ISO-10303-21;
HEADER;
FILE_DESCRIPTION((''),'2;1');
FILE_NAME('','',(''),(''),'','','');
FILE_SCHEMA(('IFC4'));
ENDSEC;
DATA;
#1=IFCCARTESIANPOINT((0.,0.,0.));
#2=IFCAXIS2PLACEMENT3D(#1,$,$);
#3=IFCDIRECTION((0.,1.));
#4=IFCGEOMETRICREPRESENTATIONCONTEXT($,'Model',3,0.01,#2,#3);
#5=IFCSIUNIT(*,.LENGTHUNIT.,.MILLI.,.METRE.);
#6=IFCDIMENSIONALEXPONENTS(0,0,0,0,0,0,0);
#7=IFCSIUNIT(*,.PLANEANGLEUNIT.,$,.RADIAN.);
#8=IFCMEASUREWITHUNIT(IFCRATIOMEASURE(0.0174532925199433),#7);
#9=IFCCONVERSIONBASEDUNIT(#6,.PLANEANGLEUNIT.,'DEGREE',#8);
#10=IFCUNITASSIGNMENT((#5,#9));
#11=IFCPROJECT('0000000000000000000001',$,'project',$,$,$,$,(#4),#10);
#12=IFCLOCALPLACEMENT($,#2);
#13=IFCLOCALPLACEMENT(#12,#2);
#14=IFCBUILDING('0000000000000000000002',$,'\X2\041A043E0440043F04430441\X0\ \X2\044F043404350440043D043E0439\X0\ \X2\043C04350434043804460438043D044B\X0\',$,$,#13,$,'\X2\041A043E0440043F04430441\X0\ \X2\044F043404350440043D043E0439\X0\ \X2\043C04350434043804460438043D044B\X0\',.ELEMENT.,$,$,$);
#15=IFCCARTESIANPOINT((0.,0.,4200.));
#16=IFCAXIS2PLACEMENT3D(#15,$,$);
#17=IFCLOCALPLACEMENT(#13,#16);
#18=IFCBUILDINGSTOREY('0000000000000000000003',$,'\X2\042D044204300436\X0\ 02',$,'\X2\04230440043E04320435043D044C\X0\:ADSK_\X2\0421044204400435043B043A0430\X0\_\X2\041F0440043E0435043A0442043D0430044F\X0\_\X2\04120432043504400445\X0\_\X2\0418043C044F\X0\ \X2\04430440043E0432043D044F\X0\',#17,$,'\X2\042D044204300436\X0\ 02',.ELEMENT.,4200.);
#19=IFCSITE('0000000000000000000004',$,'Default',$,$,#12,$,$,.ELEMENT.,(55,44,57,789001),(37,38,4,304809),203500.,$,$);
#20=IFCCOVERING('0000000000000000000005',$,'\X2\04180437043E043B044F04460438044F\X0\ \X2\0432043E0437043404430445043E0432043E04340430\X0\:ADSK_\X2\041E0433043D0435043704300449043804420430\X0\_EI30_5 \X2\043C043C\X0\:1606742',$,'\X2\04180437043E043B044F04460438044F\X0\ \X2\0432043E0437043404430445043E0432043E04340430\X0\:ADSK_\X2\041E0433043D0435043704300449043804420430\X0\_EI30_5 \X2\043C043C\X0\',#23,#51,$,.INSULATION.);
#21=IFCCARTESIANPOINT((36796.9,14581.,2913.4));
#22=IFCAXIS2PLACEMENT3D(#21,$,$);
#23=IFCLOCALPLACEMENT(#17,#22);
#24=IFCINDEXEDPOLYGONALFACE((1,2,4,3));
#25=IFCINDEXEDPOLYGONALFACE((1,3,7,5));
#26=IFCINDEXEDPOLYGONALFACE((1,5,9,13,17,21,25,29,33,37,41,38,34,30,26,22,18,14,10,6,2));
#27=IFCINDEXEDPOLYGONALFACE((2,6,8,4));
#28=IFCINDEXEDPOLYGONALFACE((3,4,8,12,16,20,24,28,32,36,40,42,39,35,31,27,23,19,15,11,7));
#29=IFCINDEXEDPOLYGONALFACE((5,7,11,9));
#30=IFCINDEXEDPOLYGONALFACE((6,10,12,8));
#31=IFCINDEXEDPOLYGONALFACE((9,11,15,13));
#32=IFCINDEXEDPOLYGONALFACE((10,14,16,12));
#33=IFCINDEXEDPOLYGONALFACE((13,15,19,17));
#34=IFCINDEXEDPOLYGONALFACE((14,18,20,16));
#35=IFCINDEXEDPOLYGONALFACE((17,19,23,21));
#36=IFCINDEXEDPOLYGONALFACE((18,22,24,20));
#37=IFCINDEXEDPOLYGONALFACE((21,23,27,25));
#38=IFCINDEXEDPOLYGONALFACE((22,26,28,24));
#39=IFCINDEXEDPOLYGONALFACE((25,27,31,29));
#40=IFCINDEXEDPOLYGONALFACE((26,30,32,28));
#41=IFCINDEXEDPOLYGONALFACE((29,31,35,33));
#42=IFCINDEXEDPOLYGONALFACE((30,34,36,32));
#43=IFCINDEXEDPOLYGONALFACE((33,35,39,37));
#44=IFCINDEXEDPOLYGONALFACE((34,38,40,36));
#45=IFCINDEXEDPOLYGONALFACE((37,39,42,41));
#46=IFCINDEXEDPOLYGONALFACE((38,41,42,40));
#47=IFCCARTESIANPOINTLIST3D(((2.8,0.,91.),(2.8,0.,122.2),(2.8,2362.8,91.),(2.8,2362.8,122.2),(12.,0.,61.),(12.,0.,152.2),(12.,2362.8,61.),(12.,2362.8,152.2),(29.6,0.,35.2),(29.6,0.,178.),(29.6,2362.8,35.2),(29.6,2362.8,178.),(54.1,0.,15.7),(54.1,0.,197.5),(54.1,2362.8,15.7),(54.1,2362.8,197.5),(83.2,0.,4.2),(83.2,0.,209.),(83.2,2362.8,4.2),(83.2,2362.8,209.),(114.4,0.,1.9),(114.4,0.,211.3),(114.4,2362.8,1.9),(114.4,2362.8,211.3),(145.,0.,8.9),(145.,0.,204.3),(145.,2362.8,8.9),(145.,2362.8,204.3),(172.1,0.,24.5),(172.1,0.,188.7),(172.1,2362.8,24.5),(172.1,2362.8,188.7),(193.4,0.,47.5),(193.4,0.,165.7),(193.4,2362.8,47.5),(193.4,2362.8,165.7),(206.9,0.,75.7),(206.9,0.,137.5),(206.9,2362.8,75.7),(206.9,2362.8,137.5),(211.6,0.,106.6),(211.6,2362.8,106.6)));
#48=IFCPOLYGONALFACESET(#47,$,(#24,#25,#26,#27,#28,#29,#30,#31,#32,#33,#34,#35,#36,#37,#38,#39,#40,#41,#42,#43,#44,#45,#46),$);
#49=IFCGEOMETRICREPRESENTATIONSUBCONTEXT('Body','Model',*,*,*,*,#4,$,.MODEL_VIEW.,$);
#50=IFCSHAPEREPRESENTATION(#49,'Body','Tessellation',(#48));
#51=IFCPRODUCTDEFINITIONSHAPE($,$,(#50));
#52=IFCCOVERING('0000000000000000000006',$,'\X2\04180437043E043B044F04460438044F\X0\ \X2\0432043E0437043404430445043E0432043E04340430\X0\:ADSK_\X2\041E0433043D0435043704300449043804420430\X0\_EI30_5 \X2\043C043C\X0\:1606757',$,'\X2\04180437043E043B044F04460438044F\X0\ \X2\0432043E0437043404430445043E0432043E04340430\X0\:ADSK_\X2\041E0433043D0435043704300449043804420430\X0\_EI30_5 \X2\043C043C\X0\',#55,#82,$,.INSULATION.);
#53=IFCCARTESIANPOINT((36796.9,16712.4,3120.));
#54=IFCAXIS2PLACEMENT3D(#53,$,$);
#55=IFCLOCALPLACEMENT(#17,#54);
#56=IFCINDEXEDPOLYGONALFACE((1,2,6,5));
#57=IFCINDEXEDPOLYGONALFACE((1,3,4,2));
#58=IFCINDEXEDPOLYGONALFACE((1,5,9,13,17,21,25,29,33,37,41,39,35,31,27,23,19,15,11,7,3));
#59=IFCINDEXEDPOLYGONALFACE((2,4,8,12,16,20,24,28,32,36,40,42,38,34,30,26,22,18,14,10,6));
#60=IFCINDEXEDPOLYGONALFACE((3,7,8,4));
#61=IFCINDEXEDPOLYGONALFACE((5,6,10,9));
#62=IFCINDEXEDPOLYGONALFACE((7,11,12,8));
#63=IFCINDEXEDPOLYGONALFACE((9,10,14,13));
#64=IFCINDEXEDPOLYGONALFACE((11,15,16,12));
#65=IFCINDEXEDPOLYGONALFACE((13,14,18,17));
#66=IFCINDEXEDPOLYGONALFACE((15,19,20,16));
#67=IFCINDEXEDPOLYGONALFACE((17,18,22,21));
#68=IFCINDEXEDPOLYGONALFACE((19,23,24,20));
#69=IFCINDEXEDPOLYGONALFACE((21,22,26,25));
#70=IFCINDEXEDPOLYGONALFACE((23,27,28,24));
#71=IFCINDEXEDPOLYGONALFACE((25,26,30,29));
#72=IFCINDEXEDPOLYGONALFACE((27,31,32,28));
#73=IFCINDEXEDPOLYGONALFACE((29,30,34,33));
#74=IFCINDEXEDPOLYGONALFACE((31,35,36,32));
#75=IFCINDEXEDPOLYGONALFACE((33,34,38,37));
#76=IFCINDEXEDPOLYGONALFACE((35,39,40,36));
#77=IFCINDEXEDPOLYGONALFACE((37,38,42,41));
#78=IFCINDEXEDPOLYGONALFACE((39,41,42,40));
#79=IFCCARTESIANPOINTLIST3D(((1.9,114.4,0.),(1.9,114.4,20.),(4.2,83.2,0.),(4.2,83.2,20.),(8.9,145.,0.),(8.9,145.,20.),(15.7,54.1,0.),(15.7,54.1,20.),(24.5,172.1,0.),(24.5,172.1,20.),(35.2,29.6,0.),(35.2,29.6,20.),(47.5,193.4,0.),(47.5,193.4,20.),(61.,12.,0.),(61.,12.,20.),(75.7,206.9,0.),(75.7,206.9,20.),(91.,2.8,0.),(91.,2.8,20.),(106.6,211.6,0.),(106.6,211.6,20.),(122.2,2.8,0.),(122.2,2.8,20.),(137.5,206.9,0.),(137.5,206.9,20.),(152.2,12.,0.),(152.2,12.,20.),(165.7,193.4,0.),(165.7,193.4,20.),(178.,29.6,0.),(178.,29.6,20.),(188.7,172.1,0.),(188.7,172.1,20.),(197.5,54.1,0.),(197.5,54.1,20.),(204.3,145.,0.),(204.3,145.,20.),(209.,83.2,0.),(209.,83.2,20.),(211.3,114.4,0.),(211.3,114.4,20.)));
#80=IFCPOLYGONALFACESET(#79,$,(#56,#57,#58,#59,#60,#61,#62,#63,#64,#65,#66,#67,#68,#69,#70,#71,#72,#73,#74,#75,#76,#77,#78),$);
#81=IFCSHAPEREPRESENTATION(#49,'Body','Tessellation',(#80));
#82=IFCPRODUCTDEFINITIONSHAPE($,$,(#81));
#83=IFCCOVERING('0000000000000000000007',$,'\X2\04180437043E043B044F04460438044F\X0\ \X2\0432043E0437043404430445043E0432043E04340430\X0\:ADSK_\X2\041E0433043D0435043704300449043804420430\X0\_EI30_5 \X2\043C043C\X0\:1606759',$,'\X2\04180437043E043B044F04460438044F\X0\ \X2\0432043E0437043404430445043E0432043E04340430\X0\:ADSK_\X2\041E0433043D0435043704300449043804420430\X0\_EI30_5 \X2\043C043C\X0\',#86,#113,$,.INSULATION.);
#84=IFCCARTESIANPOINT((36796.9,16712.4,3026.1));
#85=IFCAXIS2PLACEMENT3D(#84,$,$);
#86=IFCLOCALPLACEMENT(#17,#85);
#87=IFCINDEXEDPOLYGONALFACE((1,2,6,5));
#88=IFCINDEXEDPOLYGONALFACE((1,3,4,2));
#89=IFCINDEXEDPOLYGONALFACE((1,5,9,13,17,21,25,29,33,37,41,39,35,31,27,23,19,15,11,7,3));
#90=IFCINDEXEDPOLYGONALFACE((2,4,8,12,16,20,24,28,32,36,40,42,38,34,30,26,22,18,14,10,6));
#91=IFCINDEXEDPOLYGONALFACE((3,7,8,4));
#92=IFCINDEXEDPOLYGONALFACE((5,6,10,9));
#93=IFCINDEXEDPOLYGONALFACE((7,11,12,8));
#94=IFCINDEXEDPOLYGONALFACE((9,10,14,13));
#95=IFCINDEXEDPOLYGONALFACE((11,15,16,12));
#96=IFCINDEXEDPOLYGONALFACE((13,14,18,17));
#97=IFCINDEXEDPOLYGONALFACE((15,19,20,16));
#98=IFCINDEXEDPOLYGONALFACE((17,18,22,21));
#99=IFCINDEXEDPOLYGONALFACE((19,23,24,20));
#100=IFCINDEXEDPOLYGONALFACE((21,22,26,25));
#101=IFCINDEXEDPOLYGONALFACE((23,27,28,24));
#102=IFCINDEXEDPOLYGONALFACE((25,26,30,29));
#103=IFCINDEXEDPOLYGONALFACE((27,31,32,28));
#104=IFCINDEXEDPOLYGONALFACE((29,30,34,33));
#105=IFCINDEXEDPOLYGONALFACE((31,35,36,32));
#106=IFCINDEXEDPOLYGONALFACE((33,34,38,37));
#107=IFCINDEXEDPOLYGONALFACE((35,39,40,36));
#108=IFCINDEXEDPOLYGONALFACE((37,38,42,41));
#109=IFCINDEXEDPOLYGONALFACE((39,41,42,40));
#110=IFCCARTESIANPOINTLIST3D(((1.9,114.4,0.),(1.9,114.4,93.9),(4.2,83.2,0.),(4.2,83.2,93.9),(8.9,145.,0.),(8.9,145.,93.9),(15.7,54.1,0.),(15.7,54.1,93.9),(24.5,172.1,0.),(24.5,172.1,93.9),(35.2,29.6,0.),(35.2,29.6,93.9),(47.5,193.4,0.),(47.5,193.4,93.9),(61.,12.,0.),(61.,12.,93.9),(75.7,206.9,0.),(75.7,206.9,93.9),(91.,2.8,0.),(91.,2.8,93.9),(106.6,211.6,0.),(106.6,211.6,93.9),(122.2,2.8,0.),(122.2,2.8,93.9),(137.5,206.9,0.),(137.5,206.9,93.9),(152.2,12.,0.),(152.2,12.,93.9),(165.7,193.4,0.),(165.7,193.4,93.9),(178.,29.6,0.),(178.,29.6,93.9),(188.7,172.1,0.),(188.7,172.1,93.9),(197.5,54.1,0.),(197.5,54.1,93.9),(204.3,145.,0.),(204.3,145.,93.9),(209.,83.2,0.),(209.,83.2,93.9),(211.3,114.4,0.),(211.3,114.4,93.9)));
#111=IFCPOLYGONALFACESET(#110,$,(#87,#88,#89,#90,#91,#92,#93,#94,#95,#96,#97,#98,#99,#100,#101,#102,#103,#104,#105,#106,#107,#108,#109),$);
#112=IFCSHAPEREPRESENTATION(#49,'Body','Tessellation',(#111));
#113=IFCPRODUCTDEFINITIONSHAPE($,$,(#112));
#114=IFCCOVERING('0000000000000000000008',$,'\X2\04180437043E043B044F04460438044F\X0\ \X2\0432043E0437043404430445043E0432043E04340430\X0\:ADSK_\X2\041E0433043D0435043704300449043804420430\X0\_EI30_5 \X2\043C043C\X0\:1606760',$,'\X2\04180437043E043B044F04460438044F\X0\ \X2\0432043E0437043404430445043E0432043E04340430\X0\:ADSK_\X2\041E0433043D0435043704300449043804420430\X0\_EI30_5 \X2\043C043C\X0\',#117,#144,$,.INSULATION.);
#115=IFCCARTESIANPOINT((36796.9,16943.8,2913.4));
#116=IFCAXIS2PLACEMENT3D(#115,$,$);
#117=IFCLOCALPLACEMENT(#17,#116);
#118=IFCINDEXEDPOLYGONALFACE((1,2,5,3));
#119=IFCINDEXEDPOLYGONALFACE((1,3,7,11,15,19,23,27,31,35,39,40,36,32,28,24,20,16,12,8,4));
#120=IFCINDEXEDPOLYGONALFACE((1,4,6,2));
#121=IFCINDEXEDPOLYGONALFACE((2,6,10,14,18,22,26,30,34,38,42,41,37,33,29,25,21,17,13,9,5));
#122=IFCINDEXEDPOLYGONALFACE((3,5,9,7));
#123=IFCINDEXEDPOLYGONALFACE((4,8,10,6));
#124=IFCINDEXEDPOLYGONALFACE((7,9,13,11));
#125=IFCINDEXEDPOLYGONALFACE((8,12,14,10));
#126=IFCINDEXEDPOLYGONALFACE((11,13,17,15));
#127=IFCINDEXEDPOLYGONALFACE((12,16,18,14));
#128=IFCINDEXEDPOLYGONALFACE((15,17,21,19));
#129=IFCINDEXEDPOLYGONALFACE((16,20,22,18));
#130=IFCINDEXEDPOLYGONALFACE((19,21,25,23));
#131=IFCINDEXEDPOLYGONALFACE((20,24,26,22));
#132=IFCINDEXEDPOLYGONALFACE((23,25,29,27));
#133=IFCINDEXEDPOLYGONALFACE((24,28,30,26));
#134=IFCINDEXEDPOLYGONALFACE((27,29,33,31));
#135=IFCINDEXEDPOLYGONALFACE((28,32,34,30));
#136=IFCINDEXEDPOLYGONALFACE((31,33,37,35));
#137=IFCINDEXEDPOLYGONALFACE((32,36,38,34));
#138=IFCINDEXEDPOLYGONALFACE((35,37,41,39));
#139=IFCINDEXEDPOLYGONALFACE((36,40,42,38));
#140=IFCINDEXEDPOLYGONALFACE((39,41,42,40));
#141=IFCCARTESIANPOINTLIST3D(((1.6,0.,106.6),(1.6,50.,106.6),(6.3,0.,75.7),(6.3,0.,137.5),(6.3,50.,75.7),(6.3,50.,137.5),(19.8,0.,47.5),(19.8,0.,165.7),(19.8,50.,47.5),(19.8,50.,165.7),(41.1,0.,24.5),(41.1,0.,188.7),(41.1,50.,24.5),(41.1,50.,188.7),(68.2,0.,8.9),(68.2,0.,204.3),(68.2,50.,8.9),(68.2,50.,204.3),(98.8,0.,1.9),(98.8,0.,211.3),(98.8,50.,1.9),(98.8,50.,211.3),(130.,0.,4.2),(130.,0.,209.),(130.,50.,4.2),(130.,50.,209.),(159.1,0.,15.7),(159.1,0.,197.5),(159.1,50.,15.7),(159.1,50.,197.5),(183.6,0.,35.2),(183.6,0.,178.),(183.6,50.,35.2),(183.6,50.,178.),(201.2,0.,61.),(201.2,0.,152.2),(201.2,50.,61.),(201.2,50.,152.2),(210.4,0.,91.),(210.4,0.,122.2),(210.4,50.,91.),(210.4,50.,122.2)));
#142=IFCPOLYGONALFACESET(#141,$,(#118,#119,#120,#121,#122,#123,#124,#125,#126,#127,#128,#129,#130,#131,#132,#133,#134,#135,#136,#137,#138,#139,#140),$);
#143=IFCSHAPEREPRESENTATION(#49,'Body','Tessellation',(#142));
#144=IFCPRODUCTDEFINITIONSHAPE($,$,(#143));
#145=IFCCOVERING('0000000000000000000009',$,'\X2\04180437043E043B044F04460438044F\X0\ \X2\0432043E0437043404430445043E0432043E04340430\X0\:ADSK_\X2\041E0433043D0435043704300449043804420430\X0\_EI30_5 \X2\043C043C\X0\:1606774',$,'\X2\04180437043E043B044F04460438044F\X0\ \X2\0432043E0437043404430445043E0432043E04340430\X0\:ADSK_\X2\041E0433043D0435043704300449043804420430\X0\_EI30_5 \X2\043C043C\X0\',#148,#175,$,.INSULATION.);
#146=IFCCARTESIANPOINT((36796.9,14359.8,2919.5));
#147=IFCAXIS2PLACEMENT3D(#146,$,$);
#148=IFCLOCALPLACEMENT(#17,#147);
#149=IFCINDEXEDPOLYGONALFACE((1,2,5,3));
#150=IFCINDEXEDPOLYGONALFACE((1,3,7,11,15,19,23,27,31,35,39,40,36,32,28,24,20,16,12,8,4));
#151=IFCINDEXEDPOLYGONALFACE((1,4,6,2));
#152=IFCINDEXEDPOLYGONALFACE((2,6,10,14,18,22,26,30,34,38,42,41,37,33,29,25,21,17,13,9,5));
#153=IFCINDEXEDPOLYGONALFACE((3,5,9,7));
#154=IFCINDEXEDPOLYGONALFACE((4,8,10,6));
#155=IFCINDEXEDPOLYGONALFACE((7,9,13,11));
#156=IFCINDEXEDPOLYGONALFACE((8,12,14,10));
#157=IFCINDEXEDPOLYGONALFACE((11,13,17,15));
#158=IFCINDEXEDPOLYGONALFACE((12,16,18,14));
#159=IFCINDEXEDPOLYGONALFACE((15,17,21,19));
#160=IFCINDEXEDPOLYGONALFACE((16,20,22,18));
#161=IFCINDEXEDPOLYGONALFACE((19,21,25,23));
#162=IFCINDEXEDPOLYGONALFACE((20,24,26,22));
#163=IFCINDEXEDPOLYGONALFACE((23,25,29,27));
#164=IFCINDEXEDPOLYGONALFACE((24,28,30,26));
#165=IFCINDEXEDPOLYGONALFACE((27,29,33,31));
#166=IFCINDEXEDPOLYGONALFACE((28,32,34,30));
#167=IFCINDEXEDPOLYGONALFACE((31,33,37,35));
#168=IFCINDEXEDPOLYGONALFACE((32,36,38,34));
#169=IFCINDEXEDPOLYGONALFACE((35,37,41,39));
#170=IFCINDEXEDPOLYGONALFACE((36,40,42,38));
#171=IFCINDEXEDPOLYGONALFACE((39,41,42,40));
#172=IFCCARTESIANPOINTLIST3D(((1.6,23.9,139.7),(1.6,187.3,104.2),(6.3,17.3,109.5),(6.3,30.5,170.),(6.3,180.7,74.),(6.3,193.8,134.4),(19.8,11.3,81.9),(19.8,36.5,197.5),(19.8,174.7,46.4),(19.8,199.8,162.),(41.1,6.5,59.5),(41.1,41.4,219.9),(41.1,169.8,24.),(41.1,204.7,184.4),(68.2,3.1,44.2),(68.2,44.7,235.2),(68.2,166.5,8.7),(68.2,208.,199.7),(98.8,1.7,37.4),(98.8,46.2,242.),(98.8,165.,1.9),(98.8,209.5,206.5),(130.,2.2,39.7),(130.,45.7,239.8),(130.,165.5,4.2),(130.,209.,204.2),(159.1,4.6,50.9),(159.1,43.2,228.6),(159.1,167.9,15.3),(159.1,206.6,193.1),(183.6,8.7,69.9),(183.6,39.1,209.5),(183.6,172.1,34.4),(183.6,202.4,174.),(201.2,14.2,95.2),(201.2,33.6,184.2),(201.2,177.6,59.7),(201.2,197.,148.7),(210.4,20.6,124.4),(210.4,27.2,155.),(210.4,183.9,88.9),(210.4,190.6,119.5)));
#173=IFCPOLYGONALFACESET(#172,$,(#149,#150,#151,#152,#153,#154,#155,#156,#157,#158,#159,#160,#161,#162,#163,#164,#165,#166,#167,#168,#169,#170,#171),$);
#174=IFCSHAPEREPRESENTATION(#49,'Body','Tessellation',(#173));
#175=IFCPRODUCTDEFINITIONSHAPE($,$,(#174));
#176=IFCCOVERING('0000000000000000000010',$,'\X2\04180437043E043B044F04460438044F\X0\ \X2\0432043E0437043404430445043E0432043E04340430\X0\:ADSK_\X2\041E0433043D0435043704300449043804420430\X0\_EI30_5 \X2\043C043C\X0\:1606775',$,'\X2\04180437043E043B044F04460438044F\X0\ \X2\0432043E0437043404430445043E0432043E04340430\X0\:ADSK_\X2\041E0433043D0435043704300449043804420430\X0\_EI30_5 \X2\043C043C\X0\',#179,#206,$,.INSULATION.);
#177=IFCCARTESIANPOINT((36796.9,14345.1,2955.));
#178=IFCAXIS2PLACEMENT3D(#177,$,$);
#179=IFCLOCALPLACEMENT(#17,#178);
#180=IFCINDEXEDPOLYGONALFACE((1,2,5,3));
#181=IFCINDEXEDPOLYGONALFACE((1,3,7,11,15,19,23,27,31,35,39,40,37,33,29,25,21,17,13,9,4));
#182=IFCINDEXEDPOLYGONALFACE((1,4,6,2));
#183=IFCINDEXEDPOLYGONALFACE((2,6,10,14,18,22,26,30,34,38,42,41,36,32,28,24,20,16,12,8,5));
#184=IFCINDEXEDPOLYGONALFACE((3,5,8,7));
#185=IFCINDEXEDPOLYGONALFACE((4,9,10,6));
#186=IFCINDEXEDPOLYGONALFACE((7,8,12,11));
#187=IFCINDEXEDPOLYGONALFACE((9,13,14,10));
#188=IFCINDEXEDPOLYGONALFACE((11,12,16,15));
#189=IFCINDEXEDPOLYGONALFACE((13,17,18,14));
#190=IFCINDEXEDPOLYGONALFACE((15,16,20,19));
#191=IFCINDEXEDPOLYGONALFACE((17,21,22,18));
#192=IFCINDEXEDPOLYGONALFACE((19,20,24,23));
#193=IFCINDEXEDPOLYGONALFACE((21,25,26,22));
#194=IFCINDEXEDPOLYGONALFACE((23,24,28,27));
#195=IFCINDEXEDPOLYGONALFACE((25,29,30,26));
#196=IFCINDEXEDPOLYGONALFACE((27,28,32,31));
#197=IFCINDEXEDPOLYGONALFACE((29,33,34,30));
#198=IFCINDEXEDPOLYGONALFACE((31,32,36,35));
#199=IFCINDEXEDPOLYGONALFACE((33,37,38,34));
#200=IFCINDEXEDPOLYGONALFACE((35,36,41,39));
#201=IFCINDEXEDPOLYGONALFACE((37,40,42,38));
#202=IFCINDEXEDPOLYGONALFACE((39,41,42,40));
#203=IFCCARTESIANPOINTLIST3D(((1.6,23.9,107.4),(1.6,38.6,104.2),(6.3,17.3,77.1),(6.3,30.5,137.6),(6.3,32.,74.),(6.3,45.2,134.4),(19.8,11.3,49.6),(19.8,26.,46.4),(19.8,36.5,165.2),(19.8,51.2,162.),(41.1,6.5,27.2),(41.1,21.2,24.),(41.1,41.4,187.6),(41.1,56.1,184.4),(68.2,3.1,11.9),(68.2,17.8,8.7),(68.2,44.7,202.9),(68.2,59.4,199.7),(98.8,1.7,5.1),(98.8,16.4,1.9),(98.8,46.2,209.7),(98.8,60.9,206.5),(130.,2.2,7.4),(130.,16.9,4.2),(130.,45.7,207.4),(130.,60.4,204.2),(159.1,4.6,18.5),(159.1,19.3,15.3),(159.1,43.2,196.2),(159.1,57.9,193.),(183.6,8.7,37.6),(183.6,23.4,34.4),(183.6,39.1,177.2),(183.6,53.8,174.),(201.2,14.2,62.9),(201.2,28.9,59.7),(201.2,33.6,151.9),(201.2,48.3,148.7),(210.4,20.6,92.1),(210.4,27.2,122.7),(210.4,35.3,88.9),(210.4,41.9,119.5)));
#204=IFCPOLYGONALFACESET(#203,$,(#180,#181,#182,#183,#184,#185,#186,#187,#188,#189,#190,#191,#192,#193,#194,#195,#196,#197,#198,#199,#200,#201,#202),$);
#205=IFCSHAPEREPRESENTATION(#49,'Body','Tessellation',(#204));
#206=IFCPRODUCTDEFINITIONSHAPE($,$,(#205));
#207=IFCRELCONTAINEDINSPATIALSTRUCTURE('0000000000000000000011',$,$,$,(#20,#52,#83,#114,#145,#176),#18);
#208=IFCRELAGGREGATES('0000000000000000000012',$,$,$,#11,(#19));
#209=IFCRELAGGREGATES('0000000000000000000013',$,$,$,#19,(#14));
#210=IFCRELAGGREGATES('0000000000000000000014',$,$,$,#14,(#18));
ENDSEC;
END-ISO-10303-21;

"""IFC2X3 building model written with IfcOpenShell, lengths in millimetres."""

from ifc_helpers import new_model, entity, si_unit, converted_unit, direction, frame, origin, origin_2d_with_axis, place, context, subcontext, project, spatial, circle, extrude, element, save


model = new_model("IFC2X3")

# Units and contexts
model_context = context("Model", 3, precision=0.01, world=origin(), true_north=direction((0.0, 1.0)))
body_context = subcontext(model_context, "Body", "Model", "MODEL_VIEW")
ifc_project = project(units=[si_unit("LENGTHUNIT", "METRE", prefix="MILLI"), converted_unit("PLANEANGLEUNIT", "DEGREE", entity("IfcRatioMeasure", 0.0174532925199433), si_unit("PLANEANGLEUNIT", "RADIAN"), dimensions=[0, 0, 0, 0, 0, 0, 0])], contexts=[model_context])

# Site, building, storey
site_placement = place(None, origin())
site = spatial("IfcSite", under=ifc_project, at=site_placement, Name="Default", CompositionType="ELEMENT", RefLatitude=(55, 44, 57, 789001), RefLongitude=(37, 38, 4, 304809), RefElevation=203500.0)
building_placement = place(site_placement, origin())
building = spatial("IfcBuilding", under=site, at=building_placement, Name="Корпус ядерной медицины", LongName="Корпус ядерной медицины", CompositionType="ELEMENT")
storey_placement = place(building_placement, frame((0.0, 0.0, 4200.0)))
storey = spatial("IfcBuildingStorey", under=building, at=storey_placement, Name="Этаж 02", ObjectType="Уровень:ADSK_Стрелка_Проектная_Вверх_Имя уровня", LongName="Этаж 02", CompositionType="ELEMENT", Elevation=4200.0)

# Coverings
covering_1_placement = place(storey_placement, frame((36796.9, 14581.0, 2913.4)))
element("IfcCovering", 1, at=covering_1_placement, inside=storey, Name="Изоляция воздуховода:ADSK_Огнезащита_EI30_5 мм:1606742", ObjectType="Изоляция воздуховода:ADSK_Огнезащита_EI30_5 мм", PredefinedType="INSULATION", context=body_context, shape_type="SweptSolid", body=[
    extrude(circle(Radius=105.0, at=origin_2d_with_axis()), frame((106.6, 0.0, 106.6), z_axis=(0.0, 1.0, 0.0), x_axis=(1.0, 0.0, 0.0)), (0.0, 0.0, 1.0), 2362.8),
])
covering_2_placement = place(storey_placement, frame((36796.9, 16712.4, 3120.0)))
element("IfcCovering", 2, at=covering_2_placement, inside=storey, Name="Изоляция воздуховода:ADSK_Огнезащита_EI30_5 мм:1606757", ObjectType="Изоляция воздуховода:ADSK_Огнезащита_EI30_5 мм", PredefinedType="INSULATION", context=body_context, shape_type="SweptSolid", body=[
    extrude(circle(Radius=105.0, at=origin_2d_with_axis()), frame((106.6, 106.6, 0.0), z_axis=(0.0, 0.0, 1.0), x_axis=(0.0, 1.0, 0.0)), (0.0, 0.0, 1.0), 20.0),
])
covering_3_placement = place(storey_placement, frame((36796.9, 16712.4, 3026.1)))
element("IfcCovering", 3, at=covering_3_placement, inside=storey, Name="Изоляция воздуховода:ADSK_Огнезащита_EI30_5 мм:1606759", ObjectType="Изоляция воздуховода:ADSK_Огнезащита_EI30_5 мм", PredefinedType="INSULATION", context=body_context, shape_type="SweptSolid", body=[
    extrude(circle(Radius=105.0, at=origin_2d_with_axis()), frame((106.6, 106.6, 0.0), z_axis=(0.0, 0.0, 1.0), x_axis=(0.0, 1.0, 0.0)), (0.0, 0.0, 1.0), 93.9),
])
covering_4_placement = place(storey_placement, frame((36796.9, 16943.8, 2913.4)))
element("IfcCovering", 4, at=covering_4_placement, inside=storey, Name="Изоляция воздуховода:ADSK_Огнезащита_EI30_5 мм:1606760", ObjectType="Изоляция воздуховода:ADSK_Огнезащита_EI30_5 мм", PredefinedType="INSULATION", context=body_context, shape_type="SweptSolid", body=[
    extrude(circle(Radius=105.0, at=origin_2d_with_axis()), frame((106.6, 0.0, 106.6), z_axis=(0.0, 1.0, 0.0), x_axis=(-1.0, 0.0, 0.0)), (0.0, 0.0, 1.0), 50.0),
])
covering_5_placement = place(storey_placement, frame((36796.9, 14359.8, 2919.5)))
element("IfcCovering", 5, at=covering_5_placement, inside=storey, Name="Изоляция воздуховода:ADSK_Огнезащита_EI30_5 мм:1606774", ObjectType="Изоляция воздуховода:ADSK_Огнезащита_EI30_5 мм", PredefinedType="INSULATION", context=body_context, shape_type="SweptSolid", body=[
    extrude(circle(Radius=105.0, at=origin_2d_with_axis()), frame((106.6, 23.9, 139.7), z_axis=(0.0, 0.977156, -0.212522), x_axis=(-1.0, 0.0, 0.0)), (0.0, 0.0, 1.0), 167.2),
])
covering_6_placement = place(storey_placement, frame((36796.9, 14345.1, 2955.0)))
element("IfcCovering", 6, at=covering_6_placement, inside=storey, Name="Изоляция воздуховода:ADSK_Огнезащита_EI30_5 мм:1606775", ObjectType="Изоляция воздуховода:ADSK_Огнезащита_EI30_5 мм", PredefinedType="INSULATION", context=body_context, shape_type="SweptSolid", body=[
    extrude(circle(Radius=105.0, at=origin_2d_with_axis()), frame((106.6, 23.9, 107.4), z_axis=(0.0, 0.977156, -0.212522), x_axis=(-1.0, 0.0, 0.0)), (0.0, 0.0, 1.0), 15.0),
])

save(model, "model.ifc")
